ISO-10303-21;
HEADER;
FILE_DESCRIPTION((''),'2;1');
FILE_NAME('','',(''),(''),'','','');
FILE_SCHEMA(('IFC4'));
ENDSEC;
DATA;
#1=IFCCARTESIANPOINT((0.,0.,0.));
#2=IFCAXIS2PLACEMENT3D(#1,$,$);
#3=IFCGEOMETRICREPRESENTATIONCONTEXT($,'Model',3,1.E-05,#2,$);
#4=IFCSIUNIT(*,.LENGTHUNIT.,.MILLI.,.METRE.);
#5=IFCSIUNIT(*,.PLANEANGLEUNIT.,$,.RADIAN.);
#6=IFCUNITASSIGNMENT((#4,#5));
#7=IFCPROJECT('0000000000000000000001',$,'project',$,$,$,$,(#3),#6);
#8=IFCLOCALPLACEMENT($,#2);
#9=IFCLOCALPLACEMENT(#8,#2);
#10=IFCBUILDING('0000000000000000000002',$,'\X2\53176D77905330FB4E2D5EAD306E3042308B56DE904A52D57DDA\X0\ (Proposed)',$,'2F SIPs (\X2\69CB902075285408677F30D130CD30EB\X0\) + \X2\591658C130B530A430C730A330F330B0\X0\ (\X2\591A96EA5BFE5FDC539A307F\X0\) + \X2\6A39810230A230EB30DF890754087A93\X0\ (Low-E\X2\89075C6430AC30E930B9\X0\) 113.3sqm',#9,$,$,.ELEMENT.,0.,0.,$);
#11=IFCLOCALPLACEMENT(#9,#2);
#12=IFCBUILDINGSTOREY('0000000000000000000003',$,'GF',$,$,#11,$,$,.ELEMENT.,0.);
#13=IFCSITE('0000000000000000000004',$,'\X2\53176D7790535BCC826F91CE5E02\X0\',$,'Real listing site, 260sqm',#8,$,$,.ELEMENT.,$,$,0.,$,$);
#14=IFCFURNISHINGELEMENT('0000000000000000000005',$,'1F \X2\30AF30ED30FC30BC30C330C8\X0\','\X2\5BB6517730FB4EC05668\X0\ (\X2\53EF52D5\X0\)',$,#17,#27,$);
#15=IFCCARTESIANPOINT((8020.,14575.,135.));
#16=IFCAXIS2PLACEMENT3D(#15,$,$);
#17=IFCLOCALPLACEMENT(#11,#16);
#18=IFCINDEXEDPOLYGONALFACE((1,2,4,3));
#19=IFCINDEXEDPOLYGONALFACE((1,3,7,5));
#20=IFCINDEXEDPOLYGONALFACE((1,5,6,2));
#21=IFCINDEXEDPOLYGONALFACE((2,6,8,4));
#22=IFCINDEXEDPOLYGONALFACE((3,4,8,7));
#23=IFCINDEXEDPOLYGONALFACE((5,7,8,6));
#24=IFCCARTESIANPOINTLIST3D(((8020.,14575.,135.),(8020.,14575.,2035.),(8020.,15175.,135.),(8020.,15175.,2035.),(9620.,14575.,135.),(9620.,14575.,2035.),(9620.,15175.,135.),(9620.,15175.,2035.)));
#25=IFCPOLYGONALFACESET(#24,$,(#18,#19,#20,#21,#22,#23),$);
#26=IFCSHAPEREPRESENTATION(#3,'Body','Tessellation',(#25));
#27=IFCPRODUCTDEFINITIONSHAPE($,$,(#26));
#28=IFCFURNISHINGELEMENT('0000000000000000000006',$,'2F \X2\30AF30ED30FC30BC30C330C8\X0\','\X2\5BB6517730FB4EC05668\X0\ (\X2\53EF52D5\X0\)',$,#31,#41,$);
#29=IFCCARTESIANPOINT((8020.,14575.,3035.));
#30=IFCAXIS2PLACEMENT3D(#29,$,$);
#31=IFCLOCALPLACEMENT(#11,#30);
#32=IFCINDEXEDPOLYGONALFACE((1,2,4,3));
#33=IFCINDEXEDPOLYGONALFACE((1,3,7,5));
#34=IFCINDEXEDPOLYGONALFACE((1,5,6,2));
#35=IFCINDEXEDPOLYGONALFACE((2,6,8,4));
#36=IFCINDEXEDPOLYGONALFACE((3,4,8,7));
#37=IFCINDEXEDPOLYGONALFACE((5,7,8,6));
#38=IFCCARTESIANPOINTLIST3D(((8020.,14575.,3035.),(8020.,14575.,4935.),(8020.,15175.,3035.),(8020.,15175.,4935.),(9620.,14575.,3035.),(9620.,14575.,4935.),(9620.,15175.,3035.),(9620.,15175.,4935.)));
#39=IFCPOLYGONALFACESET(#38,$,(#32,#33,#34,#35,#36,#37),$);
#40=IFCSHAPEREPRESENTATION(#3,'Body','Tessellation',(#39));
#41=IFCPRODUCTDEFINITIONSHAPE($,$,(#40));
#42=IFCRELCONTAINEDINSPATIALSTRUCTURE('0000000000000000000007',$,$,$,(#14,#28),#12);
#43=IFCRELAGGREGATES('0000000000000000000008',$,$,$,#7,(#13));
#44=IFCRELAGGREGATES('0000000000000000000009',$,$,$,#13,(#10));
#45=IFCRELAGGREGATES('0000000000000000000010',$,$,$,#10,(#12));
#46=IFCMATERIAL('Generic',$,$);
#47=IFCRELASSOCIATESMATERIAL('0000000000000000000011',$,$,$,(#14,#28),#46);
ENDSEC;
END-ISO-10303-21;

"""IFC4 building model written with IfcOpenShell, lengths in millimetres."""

from ifc_helpers import new_model, si_unit, frame, frame_2d, origin, place, context, project, spatial, rectangle, extrude, material, element, save


model = new_model("IFC4")

# Units and contexts
model_context = context("Model", 3, precision=1e-05, world=origin())
ifc_project = project(units=[si_unit("LENGTHUNIT", "METRE", prefix="MILLI"), si_unit("PLANEANGLEUNIT", "RADIAN")], contexts=[model_context])

# Site, building, storey
site_placement = place(None, origin())
site = spatial("IfcSite", under=ifc_project, at=site_placement, Name="北海道富良野市", ObjectType="Real listing site, 260sqm", CompositionType="ELEMENT", RefElevation=0.0)
building_placement = place(site_placement, origin())
building = spatial("IfcBuilding", under=site, at=building_placement, Name="北海道・中庭のある回遊動線 (Proposed)", ObjectType="2F SIPs (構造用合板パネル) + 外壁サイディング (多雪対応厚み) + 樹脂アルミ複合窓 (Low-E複層ガラス) 113.3sqm", CompositionType="ELEMENT", ElevationOfRefHeight=0.0, ElevationOfTerrain=0.0)
storey_placement = place(building_placement, origin())
storey = spatial("IfcBuildingStorey", under=building, at=storey_placement, Name="GF", CompositionType="ELEMENT", Elevation=0.0)

# Shared definitions
ifc_material_1 = material(Name="Generic")

# Furnishing elements
furnishing_1_placement = place(storey_placement, frame((8020.0, 14575.0, 135.0)))
element("IfcFurnishingElement", 1, at=furnishing_1_placement, inside=storey, material=ifc_material_1, Name="1F クローゼット", Description="家具・什器 (可動)", context=model_context, shape_type="SweptSolid", body=[
    extrude(rectangle(XDim=1600.0, YDim=600.0, at=frame_2d((800.0, 300.0))), frame((8020.0, 14575.0, 135.0)), (0.0, 0.0, 1.0), 1900.0),
])
furnishing_2_placement = place(storey_placement, frame((8020.0, 14575.0, 3035.0)))
element("IfcFurnishingElement", 2, at=furnishing_2_placement, inside=storey, material=ifc_material_1, Name="2F クローゼット", Description="家具・什器 (可動)", context=model_context, shape_type="SweptSolid", body=[
    extrude(rectangle(XDim=1600.0, YDim=600.0, at=frame_2d((800.0, 300.0))), frame((8020.0, 14575.0, 3035.0)), (0.0, 0.0, 1.0), 1900.0),
])

save(model, "model.ifc")
